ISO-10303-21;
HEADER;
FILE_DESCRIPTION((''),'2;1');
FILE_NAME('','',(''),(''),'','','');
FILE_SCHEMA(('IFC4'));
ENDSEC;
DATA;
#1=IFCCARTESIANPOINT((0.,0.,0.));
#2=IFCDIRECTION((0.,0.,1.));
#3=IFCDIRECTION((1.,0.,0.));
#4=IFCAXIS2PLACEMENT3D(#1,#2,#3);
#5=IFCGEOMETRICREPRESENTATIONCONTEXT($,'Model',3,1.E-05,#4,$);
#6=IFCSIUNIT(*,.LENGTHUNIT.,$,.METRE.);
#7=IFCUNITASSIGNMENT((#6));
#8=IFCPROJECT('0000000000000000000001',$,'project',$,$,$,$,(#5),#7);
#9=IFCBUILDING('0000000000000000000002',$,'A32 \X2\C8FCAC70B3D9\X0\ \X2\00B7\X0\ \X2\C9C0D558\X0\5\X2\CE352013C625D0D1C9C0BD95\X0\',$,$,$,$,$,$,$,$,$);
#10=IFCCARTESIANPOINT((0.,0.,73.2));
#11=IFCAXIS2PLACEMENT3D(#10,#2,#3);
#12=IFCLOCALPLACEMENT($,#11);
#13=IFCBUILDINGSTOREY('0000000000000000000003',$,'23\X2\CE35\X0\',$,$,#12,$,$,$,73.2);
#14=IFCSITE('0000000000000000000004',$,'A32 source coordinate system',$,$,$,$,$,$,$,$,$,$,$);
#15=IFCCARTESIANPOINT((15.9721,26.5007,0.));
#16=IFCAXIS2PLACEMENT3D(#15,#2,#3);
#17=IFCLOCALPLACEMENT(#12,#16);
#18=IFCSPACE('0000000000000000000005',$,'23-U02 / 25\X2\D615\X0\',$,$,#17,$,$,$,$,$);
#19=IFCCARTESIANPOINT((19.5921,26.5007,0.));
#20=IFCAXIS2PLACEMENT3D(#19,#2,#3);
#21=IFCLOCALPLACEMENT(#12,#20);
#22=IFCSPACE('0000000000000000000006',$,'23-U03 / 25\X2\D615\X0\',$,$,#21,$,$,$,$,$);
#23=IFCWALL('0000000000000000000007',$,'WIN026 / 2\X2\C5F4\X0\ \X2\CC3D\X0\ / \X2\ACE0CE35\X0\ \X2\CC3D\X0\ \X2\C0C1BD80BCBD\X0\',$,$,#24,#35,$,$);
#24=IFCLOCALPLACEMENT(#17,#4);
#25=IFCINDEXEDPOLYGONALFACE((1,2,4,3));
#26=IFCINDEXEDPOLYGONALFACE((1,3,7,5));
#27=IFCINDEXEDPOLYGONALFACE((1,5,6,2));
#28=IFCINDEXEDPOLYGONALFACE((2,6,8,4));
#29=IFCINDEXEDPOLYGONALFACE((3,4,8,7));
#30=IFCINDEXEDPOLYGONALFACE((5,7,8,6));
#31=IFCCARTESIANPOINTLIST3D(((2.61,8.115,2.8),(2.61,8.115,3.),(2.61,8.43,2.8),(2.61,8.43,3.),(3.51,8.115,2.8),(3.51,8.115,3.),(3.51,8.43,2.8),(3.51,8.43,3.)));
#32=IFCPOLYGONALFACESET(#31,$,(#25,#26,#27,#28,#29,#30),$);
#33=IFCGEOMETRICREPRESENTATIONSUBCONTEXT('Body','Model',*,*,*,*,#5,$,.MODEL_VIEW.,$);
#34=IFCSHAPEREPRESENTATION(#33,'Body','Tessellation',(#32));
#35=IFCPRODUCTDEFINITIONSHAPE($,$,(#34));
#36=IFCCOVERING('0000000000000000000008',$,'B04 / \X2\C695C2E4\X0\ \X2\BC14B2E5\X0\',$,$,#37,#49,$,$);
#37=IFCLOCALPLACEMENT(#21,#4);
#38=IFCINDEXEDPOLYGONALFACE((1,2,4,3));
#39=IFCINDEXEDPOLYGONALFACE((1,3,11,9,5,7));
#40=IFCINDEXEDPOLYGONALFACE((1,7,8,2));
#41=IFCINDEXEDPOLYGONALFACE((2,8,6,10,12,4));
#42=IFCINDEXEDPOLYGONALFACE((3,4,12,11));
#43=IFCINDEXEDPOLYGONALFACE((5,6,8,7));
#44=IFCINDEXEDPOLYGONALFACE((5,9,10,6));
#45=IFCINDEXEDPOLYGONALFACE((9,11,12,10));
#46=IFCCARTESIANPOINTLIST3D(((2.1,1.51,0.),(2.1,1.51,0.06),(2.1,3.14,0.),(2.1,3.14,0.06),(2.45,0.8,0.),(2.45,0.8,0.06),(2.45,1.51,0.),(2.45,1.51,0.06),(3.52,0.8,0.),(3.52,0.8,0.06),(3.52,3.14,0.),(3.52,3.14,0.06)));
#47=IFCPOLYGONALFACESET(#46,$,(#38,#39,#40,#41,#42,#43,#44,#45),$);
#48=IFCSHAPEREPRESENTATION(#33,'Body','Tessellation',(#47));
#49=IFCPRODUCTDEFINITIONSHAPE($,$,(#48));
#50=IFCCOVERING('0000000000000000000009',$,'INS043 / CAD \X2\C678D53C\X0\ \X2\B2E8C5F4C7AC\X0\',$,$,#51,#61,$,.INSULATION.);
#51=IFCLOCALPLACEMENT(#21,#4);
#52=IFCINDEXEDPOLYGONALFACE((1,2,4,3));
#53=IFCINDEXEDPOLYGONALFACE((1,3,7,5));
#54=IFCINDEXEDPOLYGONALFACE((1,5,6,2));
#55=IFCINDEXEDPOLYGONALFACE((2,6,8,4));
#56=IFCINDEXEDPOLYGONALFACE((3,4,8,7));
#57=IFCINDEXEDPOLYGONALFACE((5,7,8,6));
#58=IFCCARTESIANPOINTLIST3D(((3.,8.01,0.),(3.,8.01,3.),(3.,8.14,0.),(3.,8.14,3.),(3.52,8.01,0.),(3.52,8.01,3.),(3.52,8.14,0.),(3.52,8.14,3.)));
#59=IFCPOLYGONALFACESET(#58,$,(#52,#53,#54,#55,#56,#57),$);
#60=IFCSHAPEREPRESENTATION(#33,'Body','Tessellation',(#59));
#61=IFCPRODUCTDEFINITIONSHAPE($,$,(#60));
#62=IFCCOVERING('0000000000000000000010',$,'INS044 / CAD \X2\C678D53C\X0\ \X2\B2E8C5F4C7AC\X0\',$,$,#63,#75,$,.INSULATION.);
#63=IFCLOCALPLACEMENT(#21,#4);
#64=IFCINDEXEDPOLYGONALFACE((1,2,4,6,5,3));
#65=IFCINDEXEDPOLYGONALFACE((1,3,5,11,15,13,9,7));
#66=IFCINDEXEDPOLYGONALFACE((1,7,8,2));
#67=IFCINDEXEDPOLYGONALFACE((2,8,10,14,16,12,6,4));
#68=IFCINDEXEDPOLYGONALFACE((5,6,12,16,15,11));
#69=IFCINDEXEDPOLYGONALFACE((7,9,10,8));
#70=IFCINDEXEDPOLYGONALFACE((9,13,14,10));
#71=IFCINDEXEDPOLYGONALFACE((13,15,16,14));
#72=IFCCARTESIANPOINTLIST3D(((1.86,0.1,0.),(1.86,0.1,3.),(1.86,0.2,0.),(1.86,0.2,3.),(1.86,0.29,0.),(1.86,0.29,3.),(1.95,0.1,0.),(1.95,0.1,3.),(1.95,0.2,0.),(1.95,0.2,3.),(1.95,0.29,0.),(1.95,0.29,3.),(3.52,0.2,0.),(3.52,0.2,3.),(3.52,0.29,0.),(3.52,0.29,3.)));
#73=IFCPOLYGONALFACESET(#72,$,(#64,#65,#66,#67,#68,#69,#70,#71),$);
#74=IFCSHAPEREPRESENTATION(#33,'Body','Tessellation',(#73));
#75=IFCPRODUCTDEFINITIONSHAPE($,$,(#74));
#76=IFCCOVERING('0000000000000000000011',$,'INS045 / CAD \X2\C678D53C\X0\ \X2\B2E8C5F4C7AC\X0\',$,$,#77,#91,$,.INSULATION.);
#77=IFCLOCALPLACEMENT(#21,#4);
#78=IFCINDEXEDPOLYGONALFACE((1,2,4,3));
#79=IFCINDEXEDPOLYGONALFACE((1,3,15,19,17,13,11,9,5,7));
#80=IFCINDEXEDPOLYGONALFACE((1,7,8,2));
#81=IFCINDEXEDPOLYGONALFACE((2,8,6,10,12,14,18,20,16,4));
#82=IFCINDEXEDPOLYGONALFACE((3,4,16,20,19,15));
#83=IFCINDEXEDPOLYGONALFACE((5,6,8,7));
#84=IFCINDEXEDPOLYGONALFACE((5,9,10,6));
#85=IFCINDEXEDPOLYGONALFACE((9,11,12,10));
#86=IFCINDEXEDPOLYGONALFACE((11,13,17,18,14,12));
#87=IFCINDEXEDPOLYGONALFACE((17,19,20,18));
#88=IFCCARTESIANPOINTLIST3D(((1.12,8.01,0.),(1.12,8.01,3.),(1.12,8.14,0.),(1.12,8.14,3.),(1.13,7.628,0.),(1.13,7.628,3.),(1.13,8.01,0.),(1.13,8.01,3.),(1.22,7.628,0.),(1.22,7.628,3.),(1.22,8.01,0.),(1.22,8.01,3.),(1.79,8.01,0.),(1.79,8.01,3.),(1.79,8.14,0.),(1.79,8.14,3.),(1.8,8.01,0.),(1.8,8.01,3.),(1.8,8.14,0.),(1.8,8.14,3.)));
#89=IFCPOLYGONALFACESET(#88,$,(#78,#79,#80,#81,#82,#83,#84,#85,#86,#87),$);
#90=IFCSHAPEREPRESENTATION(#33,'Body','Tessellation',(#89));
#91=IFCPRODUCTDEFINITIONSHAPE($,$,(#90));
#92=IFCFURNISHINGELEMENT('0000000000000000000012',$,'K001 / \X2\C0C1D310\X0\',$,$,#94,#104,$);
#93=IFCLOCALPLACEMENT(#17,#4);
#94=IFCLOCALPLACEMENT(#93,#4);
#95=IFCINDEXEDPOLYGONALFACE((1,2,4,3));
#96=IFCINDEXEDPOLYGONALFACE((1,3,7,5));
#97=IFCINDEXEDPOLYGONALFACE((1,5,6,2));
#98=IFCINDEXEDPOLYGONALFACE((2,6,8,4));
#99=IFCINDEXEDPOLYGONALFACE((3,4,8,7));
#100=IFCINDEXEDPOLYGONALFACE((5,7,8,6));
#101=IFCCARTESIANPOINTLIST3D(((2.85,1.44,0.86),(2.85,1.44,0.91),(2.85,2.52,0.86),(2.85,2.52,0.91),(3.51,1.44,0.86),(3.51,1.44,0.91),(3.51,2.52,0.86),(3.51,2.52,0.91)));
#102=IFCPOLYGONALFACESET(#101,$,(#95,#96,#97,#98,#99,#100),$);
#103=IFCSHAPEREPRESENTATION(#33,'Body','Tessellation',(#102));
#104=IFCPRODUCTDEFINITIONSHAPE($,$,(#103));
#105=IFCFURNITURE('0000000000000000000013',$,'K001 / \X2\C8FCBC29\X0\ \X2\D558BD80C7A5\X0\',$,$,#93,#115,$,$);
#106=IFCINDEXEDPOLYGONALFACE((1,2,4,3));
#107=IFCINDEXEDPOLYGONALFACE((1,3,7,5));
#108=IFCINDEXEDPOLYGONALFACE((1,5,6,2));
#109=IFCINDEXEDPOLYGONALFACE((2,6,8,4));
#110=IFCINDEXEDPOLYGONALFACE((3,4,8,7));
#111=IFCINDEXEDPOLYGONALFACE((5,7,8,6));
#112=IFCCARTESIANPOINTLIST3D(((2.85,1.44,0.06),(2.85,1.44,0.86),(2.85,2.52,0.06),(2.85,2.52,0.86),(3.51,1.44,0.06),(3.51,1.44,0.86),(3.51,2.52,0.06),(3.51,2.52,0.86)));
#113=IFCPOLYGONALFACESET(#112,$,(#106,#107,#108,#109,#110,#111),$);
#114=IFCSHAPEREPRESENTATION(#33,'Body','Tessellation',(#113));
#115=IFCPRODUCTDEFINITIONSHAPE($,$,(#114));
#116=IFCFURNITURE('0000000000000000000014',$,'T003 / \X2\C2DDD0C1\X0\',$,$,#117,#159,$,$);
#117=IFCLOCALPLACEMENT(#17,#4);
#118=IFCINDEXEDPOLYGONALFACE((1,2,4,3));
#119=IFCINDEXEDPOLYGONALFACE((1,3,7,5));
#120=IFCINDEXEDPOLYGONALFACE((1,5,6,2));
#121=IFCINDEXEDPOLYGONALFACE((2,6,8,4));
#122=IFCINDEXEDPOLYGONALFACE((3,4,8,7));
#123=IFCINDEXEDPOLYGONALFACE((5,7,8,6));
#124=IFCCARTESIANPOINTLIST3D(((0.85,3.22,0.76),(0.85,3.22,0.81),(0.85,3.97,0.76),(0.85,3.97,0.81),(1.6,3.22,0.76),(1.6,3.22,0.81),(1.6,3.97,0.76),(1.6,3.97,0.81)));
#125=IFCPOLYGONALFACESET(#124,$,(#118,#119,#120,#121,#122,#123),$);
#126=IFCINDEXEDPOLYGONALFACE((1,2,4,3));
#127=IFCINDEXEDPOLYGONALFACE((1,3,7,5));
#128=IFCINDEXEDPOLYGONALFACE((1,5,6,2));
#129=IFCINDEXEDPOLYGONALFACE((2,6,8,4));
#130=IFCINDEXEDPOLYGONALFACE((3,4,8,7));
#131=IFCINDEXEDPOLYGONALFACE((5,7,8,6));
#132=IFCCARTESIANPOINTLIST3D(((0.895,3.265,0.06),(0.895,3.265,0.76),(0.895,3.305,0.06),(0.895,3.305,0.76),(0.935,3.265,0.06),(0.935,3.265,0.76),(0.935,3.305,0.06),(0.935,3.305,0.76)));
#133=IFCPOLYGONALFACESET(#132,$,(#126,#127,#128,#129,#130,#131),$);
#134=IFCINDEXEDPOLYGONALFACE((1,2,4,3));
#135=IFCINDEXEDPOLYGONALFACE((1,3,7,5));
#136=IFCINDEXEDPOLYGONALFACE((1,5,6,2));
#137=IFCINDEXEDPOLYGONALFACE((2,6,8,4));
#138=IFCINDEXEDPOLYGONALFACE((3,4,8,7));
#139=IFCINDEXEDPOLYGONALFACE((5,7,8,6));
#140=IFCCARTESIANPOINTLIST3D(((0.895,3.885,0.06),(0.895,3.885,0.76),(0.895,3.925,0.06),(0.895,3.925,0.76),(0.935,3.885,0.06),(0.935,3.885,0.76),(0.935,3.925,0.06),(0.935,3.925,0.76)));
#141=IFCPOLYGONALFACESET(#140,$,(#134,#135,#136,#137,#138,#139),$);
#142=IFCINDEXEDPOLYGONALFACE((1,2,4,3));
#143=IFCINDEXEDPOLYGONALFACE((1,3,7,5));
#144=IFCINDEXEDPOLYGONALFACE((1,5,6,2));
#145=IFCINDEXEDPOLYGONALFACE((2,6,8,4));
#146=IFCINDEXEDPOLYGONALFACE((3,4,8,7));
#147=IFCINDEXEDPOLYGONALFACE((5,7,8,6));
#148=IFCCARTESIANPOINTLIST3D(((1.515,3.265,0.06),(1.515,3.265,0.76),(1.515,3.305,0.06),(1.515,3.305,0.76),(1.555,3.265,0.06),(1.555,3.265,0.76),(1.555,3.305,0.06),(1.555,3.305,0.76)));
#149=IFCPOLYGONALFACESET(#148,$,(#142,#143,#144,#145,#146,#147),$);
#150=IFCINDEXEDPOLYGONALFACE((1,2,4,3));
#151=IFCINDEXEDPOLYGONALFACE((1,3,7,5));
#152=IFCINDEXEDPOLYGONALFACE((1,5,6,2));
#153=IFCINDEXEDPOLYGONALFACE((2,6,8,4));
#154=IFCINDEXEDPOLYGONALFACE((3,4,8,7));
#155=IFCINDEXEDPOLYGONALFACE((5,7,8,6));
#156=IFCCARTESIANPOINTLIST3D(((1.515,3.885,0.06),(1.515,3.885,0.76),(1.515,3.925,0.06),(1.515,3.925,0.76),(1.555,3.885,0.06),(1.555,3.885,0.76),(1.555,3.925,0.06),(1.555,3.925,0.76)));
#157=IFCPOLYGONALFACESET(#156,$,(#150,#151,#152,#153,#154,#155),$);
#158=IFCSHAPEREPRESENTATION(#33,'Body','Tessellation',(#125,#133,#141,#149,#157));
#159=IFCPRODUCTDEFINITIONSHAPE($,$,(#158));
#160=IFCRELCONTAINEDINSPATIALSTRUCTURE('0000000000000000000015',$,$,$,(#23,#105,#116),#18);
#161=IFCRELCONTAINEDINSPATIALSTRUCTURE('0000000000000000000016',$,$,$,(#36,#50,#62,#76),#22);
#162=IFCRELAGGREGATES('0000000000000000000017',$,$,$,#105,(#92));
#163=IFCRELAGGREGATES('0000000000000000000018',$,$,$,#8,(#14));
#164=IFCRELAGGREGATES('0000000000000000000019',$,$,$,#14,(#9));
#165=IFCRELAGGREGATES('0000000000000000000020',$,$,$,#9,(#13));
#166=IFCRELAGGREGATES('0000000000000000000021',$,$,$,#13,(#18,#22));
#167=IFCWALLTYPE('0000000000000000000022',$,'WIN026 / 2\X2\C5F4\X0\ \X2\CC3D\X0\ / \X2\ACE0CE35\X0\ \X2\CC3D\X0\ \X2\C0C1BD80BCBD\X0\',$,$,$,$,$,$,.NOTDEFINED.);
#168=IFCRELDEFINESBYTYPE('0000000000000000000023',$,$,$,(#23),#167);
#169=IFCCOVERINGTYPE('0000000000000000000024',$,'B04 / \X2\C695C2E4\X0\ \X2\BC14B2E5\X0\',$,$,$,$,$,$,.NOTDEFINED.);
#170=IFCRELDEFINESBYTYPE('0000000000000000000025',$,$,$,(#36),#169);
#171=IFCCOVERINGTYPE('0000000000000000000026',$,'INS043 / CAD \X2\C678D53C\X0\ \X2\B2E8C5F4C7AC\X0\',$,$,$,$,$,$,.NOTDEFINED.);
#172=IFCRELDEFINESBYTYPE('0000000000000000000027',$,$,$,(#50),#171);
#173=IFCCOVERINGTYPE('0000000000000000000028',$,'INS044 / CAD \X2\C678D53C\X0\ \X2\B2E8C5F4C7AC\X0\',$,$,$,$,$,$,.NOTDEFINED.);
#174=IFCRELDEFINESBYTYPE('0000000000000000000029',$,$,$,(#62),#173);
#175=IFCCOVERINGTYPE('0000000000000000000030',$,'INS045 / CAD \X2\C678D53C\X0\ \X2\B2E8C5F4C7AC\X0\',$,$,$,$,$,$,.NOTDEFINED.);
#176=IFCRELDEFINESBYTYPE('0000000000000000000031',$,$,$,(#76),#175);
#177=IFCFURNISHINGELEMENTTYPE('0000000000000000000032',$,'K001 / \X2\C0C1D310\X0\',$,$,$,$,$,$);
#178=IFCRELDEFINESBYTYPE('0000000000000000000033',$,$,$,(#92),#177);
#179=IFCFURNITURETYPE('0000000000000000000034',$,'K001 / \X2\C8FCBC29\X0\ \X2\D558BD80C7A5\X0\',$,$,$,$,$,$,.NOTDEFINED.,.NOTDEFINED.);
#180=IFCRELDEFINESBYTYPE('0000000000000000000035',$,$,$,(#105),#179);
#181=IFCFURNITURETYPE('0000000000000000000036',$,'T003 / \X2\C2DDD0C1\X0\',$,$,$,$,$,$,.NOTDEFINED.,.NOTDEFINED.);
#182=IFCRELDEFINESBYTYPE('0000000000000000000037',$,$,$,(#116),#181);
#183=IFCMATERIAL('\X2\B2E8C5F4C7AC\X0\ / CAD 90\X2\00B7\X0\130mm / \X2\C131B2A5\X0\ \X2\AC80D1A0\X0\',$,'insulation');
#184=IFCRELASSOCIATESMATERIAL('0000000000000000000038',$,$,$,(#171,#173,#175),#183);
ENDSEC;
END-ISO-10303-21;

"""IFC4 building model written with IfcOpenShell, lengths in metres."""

from ifc_helpers import new_model, si_unit, frame, origin, origin_with_axes, place, context, subcontext, project, spatial, polyline, outline, extrude, source, transform, mapped, material, type_object, type_shapes, element, aggregate, save


model = new_model("IFC4")

# Units and contexts
model_context = context("Model", 3, precision=1e-05, world=origin_with_axes())
body_context = subcontext(model_context, "Body", "Model", "MODEL_VIEW")
ifc_project = project(units=[si_unit("LENGTHUNIT", "METRE")], contexts=[model_context])

# Site, building, storey, space
site = spatial("IfcSite", under=ifc_project, Name="A32 source coordinate system")
building = spatial("IfcBuilding", under=site, Name="A32 주거동 · 지하5층–옥탑지붕")
storey_placement = place(None, frame((0.0, 0.0, 73.2), z_axis=(0.0, 0.0, 1.0), x_axis=(1.0, 0.0, 0.0)))
storey = spatial("IfcBuildingStorey", under=building, at=storey_placement, Name="23층", Elevation=73.2)
space_1_placement = place(storey_placement, frame((15.9721, 26.5007, 0.0), z_axis=(0.0, 0.0, 1.0), x_axis=(1.0, 0.0, 0.0)))
space_1 = spatial("IfcSpace", under=storey, at=space_1_placement, Name="23-U02 / 25형")

# Wall
wall_type_1 = type_object("IfcWallType", Name="WIN026 / 2열 창 / 고층 창 상부벽", PredefinedType="NOTDEFINED")
shared_shape_1 = source(origin(), body_context, "Body", "SweptSolid", [
    extrude(outline(polyline([(3.51, 8.115), (3.51, 8.43), (2.61, 8.43), (2.61, 8.115), (3.51, 8.115)])), frame((0.0, 0.0, 2.8)), (0.0, 0.0, 1.0), 0.2),
])
type_shapes(wall_type_1, [shared_shape_1])
wall_1_placement = place(space_1_placement, origin_with_axes())
element("IfcWall", 1, at=wall_1_placement, inside=space_1, type_object=wall_type_1, Name="WIN026 / 2열 창 / 고층 창 상부벽", context=body_context, shape_type="MappedRepresentation", body=[
    mapped(shared_shape_1, transform((0.0, 0.0, 0.0), scale=1.0)),
])

# Shared definitions
space_2_placement = place(storey_placement, frame((19.5921, 26.5007, 0.0), z_axis=(0.0, 0.0, 1.0), x_axis=(1.0, 0.0, 0.0)))
space_2 = spatial("IfcSpace", under=storey, at=space_2_placement, Name="23-U03 / 25형")

# Coverings
covering_type_1 = type_object("IfcCoveringType", Name="B04 / 욕실 바닥", PredefinedType="NOTDEFINED")
shared_shape_2 = source(origin(), body_context, "Body", "SweptSolid", [
    extrude(outline(polyline([(2.1, 1.51), (2.1, 3.14), (3.52, 3.14), (3.52, 0.8), (2.45, 0.8), (2.45, 1.51), (2.1, 1.51)])), origin(), (0.0, 0.0, 1.0), 0.06),
])
type_shapes(covering_type_1, [shared_shape_2])
covering_1_placement = place(space_2_placement, origin_with_axes())
element("IfcCovering", 2, at=covering_1_placement, inside=space_2, type_object=covering_type_1, Name="B04 / 욕실 바닥", context=body_context, shape_type="MappedRepresentation", body=[
    mapped(shared_shape_2, transform((0.0, 0.0, 0.0), scale=1.0)),
])
ifc_material = material(Name="단열재 / CAD 90·130mm / 성능 검토", Category="insulation")
covering_type_2 = type_object("IfcCoveringType", Name="INS043 / CAD 외피 단열재", PredefinedType="NOTDEFINED", material=ifc_material)
shared_shape_3 = source(origin(), body_context, "Body", "SweptSolid", [
    extrude(outline(polyline([(3.52, 8.14), (3.52, 8.01), (3.0, 8.01), (3.0, 8.14), (3.52, 8.14)])), origin(), (0.0, 0.0, 1.0), 3.0),
])
type_shapes(covering_type_2, [shared_shape_3])
covering_2_placement = place(space_2_placement, origin_with_axes())
element("IfcCovering", 3, at=covering_2_placement, inside=space_2, type_object=covering_type_2, Name="INS043 / CAD 외피 단열재", PredefinedType="INSULATION", context=body_context, shape_type="MappedRepresentation", body=[
    mapped(shared_shape_3, transform((0.0, 0.0, 0.0), scale=1.0)),
])
covering_type_3 = type_object("IfcCoveringType", Name="INS044 / CAD 외피 단열재", PredefinedType="NOTDEFINED", material=ifc_material)
shared_shape_4 = source(origin(), body_context, "Body", "SweptSolid", [
    extrude(outline(polyline([(1.86, 0.2), (1.86, 0.29), (1.95, 0.29), (3.52, 0.29), (3.52, 0.2), (1.95, 0.2), (1.95, 0.1), (1.86, 0.1), (1.86, 0.2)])), origin(), (0.0, 0.0, 1.0), 3.0),
])
type_shapes(covering_type_3, [shared_shape_4])
covering_3_placement = place(space_2_placement, origin_with_axes())
element("IfcCovering", 4, at=covering_3_placement, inside=space_2, type_object=covering_type_3, Name="INS044 / CAD 외피 단열재", PredefinedType="INSULATION", context=body_context, shape_type="MappedRepresentation", body=[
    mapped(shared_shape_4, transform((0.0, 0.0, 0.0), scale=1.0)),
])
covering_type_4 = type_object("IfcCoveringType", Name="INS045 / CAD 외피 단열재", PredefinedType="NOTDEFINED", material=ifc_material)
shared_shape_5 = source(origin(), body_context, "Body", "SweptSolid", [
    extrude(outline(polyline([(1.22, 8.01), (1.22, 7.628), (1.13, 7.628), (1.13, 8.01), (1.12, 8.01), (1.12, 8.14), (1.79, 8.14), (1.8, 8.14), (1.8, 8.01), (1.79, 8.01), (1.22, 8.01)])), origin(), (0.0, 0.0, 1.0), 3.0),
])
type_shapes(covering_type_4, [shared_shape_5])
covering_4_placement = place(space_2_placement, origin_with_axes())
element("IfcCovering", 5, at=covering_4_placement, inside=space_2, type_object=covering_type_4, Name="INS045 / CAD 외피 단열재", PredefinedType="INSULATION", context=body_context, shape_type="MappedRepresentation", body=[
    mapped(shared_shape_5, transform((0.0, 0.0, 0.0), scale=1.0)),
])

# Furnishing element
furnishing_element_type_1 = type_object("IfcFurnishingElementType", Name="K001 / 상판")
shared_shape_6 = source(origin(), body_context, "Body", "SweptSolid", [
    extrude(outline(polyline([(2.85, 2.52), (3.51, 2.52), (3.51, 1.44), (2.85, 1.44), (2.85, 2.52)])), frame((0.0, 0.0, 0.86)), (0.0, 0.0, 1.0), 0.05),
])
type_shapes(furnishing_element_type_1, [shared_shape_6])
furniture_1_placement = place(space_1_placement, origin_with_axes())
furnishing_1_placement = place(furniture_1_placement, origin_with_axes())
furnishing_1 = element("IfcFurnishingElement", 6, at=furnishing_1_placement, type_object=furnishing_element_type_1, Name="K001 / 상판", context=body_context, shape_type="MappedRepresentation", body=[
    mapped(shared_shape_6, transform((0.0, 0.0, 0.0), scale=1.0)),
])

# Furniture
furniture_type_1 = type_object("IfcFurnitureType", Name="K001 / 주방 하부장", AssemblyPlace="NOTDEFINED", PredefinedType="NOTDEFINED")
shared_shape_7 = source(origin(), body_context, "Body", "SweptSolid", [
    extrude(outline(polyline([(2.85, 1.44), (2.85, 2.52), (3.51, 2.52), (3.51, 1.44), (2.85, 1.44)])), frame((0.0, 0.0, 0.06)), (0.0, 0.0, 1.0), 0.8),
])
type_shapes(furniture_type_1, [shared_shape_7])
furniture_1 = element("IfcFurniture", 7, at=furniture_1_placement, inside=space_1, type_object=furniture_type_1, Name="K001 / 주방 하부장", context=body_context, shape_type="MappedRepresentation", body=[
    mapped(shared_shape_7, transform((0.0, 0.0, 0.0), scale=1.0)),
])
aggregate(furniture_1, [furnishing_1])
furniture_type_2 = type_object("IfcFurnitureType", Name="T003 / 식탁", AssemblyPlace="NOTDEFINED", PredefinedType="NOTDEFINED")
shared_shape_8 = source(origin(), body_context, "Body", "SweptSolid", [
    extrude(outline(polyline([(1.6, 3.97), (1.6, 3.22), (0.85, 3.22), (0.85, 3.97), (1.6, 3.97)])), frame((0.0, 0.0, 0.76)), (0.0, 0.0, 1.0), 0.05),
    extrude(outline(polyline([(0.895, 3.265), (0.895, 3.305), (0.935, 3.305), (0.935, 3.265), (0.895, 3.265)])), frame((0.0, 0.0, 0.06)), (0.0, 0.0, 1.0), 0.7),
    extrude(outline(polyline([(0.895, 3.885), (0.895, 3.925), (0.935, 3.925), (0.935, 3.885), (0.895, 3.885)])), frame((0.0, 0.0, 0.06)), (0.0, 0.0, 1.0), 0.7),
    extrude(outline(polyline([(1.515, 3.265), (1.515, 3.305), (1.555, 3.305), (1.555, 3.265), (1.515, 3.265)])), frame((0.0, 0.0, 0.06)), (0.0, 0.0, 1.0), 0.7),
    extrude(outline(polyline([(1.515, 3.885), (1.515, 3.925), (1.555, 3.925), (1.555, 3.885), (1.515, 3.885)])), frame((0.0, 0.0, 0.06)), (0.0, 0.0, 1.0), 0.7),
])
type_shapes(furniture_type_2, [shared_shape_8])
furniture_2_placement = place(space_1_placement, origin_with_axes())
element("IfcFurniture", 8, at=furniture_2_placement, inside=space_1, type_object=furniture_type_2, Name="T003 / 식탁", context=body_context, shape_type="MappedRepresentation", body=[
    mapped(shared_shape_8, transform((0.0, 0.0, 0.0), scale=1.0)),
])

save(model, "model.ifc")
